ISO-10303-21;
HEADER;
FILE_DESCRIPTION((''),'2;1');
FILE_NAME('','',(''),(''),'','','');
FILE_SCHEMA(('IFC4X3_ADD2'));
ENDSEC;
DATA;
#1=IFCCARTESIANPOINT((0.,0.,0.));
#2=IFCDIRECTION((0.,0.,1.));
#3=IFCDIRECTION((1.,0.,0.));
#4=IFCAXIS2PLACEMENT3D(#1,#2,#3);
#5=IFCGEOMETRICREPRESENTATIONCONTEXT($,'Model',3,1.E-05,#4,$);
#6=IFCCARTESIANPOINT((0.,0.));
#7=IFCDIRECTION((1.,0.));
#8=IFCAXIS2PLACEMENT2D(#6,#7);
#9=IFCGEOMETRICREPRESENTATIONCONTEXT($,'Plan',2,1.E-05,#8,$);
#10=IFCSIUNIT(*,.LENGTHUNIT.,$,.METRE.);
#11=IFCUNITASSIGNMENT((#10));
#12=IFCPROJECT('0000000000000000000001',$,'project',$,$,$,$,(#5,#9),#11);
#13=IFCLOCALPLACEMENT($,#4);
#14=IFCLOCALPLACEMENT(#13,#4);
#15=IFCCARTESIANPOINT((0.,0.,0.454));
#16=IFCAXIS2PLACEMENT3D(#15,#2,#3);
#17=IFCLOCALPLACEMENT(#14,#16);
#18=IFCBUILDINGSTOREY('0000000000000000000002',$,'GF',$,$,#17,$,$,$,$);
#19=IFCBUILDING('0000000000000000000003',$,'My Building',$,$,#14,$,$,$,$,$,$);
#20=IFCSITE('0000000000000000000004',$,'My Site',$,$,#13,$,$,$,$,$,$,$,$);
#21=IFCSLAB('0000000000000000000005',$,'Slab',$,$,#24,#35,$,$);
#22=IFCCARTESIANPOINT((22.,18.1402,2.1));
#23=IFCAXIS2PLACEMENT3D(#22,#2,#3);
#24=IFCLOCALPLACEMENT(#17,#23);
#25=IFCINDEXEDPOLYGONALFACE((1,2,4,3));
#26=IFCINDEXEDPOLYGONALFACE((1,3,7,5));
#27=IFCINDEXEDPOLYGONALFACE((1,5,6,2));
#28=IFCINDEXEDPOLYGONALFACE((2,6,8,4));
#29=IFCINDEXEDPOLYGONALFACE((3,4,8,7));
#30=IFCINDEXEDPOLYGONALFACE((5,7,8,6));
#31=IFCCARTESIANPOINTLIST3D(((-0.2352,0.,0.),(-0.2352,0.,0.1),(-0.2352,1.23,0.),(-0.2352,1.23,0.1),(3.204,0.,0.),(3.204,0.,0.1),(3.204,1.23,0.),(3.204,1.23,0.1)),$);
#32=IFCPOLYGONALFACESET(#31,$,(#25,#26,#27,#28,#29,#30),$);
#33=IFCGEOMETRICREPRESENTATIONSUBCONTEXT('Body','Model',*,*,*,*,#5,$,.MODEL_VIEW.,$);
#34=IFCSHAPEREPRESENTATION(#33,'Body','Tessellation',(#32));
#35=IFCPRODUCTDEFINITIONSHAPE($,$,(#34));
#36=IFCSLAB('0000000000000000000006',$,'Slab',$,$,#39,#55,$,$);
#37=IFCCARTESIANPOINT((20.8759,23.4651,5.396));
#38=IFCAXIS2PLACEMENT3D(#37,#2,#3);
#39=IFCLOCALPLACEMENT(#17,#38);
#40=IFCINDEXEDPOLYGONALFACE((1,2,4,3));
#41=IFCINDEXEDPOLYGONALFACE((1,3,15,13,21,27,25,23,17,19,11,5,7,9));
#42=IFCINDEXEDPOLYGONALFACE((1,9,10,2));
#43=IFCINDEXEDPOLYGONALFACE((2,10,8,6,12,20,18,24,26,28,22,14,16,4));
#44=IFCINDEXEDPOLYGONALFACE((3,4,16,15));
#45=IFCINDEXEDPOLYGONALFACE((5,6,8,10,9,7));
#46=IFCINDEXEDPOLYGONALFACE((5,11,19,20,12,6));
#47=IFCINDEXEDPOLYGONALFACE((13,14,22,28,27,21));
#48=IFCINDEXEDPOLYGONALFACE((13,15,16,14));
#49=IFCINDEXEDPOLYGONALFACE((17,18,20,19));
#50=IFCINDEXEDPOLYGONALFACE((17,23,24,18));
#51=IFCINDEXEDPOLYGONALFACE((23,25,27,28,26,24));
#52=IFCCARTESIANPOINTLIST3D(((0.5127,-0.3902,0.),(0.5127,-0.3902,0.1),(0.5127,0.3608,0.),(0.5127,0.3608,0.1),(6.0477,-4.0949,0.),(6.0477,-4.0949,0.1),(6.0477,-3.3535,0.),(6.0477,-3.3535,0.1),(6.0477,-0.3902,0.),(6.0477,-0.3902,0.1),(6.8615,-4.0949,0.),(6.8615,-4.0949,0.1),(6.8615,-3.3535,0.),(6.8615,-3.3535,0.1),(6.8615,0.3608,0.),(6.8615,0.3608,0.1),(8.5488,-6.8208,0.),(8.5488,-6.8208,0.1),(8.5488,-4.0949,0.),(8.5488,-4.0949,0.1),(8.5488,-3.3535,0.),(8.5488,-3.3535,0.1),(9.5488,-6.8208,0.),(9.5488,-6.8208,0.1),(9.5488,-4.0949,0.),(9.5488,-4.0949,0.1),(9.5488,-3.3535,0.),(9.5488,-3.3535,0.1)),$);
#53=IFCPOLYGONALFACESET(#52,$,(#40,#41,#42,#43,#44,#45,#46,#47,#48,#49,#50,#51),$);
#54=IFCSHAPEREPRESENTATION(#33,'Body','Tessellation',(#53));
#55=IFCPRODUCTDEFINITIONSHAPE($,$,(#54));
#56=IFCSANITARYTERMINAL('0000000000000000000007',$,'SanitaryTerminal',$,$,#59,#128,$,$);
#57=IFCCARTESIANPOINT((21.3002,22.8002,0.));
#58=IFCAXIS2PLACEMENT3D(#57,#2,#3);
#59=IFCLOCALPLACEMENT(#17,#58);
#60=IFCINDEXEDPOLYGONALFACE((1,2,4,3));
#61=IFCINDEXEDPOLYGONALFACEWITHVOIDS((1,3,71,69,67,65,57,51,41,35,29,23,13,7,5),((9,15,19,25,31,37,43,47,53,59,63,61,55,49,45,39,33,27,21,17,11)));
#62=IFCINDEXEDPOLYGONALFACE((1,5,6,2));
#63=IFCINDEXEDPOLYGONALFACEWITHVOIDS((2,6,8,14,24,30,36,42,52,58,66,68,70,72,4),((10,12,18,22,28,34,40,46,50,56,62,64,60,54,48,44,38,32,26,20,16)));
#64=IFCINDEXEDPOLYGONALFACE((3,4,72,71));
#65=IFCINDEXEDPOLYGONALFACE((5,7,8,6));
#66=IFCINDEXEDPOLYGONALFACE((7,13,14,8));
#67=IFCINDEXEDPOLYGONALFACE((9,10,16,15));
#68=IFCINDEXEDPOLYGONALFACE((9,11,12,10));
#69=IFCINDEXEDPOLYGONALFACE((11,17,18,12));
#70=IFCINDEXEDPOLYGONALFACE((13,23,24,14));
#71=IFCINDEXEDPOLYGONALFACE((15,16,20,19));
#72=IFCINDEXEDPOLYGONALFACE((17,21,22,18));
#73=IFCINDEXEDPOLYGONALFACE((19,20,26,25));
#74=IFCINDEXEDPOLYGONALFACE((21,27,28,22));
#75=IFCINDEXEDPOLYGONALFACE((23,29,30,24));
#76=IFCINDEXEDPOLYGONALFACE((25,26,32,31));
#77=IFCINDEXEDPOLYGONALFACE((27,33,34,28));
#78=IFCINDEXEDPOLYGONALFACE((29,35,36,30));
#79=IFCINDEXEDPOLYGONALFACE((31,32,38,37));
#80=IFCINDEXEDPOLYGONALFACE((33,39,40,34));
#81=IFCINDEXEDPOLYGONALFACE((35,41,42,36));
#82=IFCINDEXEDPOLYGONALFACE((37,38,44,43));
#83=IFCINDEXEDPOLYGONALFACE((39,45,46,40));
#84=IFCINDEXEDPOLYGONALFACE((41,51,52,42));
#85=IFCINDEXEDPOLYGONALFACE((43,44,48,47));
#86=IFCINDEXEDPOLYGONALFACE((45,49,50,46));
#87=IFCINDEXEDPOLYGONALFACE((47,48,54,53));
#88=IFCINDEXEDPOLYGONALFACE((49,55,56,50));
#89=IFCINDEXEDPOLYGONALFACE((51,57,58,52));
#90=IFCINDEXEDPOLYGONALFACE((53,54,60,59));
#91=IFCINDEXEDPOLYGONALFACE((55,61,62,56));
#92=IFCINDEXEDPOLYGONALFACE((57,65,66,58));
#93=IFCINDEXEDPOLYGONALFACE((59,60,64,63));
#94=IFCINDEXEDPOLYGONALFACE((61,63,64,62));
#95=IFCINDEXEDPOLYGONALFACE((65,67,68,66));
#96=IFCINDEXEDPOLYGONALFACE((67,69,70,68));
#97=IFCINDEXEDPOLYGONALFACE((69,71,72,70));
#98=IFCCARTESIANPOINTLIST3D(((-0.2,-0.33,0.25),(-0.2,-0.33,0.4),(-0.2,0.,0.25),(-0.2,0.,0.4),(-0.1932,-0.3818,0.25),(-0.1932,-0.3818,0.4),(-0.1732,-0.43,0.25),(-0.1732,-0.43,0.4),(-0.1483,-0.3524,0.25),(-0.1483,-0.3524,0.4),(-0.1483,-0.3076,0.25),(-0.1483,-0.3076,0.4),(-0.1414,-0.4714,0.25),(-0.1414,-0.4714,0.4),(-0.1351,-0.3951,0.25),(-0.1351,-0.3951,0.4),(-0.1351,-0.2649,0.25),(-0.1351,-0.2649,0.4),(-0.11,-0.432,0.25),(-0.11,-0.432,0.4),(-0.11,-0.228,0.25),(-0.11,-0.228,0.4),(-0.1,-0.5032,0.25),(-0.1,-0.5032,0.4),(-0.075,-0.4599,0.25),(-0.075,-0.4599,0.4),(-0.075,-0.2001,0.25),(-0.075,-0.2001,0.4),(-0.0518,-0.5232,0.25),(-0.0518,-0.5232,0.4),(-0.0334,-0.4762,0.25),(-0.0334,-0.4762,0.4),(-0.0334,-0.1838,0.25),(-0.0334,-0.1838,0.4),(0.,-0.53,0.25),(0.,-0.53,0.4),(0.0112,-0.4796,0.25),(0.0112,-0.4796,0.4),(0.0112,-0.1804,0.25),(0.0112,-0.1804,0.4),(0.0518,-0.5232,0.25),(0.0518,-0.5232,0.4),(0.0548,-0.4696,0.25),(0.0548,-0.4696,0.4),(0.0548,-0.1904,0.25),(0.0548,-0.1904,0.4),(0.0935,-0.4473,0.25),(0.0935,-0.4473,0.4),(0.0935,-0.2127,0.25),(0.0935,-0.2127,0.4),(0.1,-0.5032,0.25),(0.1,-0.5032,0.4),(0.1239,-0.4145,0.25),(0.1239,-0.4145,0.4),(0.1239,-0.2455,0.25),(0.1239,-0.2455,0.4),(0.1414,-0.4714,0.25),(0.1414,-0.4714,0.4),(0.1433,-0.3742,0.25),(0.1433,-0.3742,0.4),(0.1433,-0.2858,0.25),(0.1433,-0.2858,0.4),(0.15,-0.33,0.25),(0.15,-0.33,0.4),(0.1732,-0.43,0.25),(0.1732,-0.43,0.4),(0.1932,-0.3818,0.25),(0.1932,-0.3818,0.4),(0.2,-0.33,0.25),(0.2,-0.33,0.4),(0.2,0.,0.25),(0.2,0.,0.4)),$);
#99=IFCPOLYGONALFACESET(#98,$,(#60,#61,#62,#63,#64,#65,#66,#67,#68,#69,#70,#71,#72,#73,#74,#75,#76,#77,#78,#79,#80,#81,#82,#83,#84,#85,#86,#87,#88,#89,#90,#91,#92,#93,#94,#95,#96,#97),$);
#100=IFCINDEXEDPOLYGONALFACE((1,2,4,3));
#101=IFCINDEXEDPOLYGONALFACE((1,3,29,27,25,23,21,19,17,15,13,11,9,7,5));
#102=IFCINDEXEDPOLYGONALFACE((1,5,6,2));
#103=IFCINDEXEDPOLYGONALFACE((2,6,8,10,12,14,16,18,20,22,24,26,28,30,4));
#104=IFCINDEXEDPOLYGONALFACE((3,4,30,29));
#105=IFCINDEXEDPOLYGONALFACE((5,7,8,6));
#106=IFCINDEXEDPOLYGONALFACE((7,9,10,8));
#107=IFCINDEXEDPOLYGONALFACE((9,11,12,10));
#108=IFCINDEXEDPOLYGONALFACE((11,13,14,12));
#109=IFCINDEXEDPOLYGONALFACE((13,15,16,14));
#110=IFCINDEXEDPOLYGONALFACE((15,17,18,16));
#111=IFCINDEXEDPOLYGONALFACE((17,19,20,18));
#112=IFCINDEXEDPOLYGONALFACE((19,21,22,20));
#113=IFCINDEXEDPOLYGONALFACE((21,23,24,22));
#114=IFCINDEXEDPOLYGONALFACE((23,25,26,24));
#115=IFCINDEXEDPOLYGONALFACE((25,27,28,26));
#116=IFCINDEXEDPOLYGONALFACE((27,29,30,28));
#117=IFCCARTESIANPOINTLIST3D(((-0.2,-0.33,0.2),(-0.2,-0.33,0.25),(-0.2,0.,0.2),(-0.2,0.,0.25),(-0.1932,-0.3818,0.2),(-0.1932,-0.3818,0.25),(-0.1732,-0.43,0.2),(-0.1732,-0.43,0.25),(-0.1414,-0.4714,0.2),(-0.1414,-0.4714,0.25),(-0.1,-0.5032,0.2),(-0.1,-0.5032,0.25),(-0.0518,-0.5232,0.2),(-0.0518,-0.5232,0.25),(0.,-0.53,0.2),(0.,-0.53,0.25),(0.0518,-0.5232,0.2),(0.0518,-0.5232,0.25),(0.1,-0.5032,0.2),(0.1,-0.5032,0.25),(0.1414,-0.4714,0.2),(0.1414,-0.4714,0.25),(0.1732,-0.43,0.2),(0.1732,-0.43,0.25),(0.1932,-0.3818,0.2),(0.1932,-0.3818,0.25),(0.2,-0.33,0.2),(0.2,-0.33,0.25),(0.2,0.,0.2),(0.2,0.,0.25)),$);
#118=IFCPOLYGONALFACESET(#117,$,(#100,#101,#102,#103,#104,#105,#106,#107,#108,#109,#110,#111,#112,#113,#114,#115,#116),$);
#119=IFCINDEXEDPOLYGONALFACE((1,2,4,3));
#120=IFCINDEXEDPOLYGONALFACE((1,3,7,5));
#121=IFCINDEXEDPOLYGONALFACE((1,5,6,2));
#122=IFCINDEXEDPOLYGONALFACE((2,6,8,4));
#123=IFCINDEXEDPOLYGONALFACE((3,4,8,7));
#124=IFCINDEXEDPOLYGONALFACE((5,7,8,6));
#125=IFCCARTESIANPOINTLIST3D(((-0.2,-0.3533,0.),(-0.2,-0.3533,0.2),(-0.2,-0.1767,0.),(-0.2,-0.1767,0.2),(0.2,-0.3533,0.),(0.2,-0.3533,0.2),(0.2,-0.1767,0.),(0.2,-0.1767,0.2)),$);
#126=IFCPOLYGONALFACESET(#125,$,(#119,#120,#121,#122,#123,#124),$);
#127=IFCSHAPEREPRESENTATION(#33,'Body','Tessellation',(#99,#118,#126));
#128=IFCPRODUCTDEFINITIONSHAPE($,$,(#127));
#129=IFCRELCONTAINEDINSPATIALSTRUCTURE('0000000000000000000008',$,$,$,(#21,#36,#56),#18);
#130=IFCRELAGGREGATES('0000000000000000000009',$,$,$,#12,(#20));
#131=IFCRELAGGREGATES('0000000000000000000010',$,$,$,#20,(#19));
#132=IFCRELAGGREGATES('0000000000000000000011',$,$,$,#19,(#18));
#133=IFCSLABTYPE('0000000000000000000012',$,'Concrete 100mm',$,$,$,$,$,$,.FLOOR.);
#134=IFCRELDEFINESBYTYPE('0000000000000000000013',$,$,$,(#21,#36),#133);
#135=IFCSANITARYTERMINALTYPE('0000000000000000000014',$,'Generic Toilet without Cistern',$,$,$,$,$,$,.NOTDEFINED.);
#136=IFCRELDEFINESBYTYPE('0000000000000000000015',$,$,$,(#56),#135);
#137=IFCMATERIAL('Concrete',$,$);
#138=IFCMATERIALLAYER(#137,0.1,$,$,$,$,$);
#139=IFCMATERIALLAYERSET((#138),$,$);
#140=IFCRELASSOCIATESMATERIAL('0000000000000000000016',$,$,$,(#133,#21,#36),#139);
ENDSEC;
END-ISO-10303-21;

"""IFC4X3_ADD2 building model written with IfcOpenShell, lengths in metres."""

from ifc_helpers import new_model, entity, si_unit, frame, frame_2d, origin_with_axes, origin_2d_with_axis, place, context, subcontext, project, spatial, line, arc, indexed_curve, circle_curve, outline, extrude, shape, source, transform, mapped, material, layer, layer_set, layer_usage, type_object, type_shapes, element, save


model = new_model("IFC4X3_ADD2")

# Units and contexts
model_context = context("Model", 3, precision=1e-05, world=origin_with_axes())
plan_context = context("Plan", 2, precision=1e-05, world=origin_2d_with_axis())
body_context_1 = subcontext(model_context, "Body", "Model", "MODEL_VIEW")
body_context_2 = subcontext(plan_context, "Body", "Plan", "PLAN_VIEW")
ifc_project = project(units=[si_unit("LENGTHUNIT", "METRE")], contexts=[model_context, plan_context])

# Site, building, storey
site_placement = place(None, origin_with_axes())
site = spatial("IfcSite", under=ifc_project, at=site_placement, Name="My Site")
building_placement = place(site_placement, origin_with_axes())
building = spatial("IfcBuilding", under=site, at=building_placement, Name="My Building")
storey_placement = place(building_placement, frame((0.0, 0.0, 0.454), z_axis=(0.0, 0.0, 1.0), x_axis=(1.0, 0.0, 0.0)))
storey = spatial("IfcBuildingStorey", under=building, at=storey_placement, Name="GF")

# Slabs
ifc_material_1 = material(Name="Concrete")
ifc_layer_1 = layer(ifc_material_1, 0.1)
ifc_layer_set_1 = layer_set([ifc_layer_1])
ifc_layer_usage_1 = layer_usage(ifc_layer_set_1, "AXIS3", "POSITIVE", 0.0)
slab_type = type_object("IfcSlabType", Name="Concrete 100mm", PredefinedType="FLOOR", material=ifc_layer_set_1)
slab_1_placement = place(storey_placement, frame((22.0, 18.1402, 2.1), z_axis=(0.0, 0.0, 1.0), x_axis=(1.0, 0.0, 0.0)))
element("IfcSlab", 1, at=slab_1_placement, inside=storey, type_object=slab_type, material=ifc_layer_usage_1, Name="Slab", context=body_context_1, shape_type="SweptSolid", body=[
    extrude(outline(indexed_curve([(3.204, 0.0), (-0.2352, 0.0), (-0.2352, 1.23), (3.204, 1.23)], segments=[line(3, 2), line(2, 1), line(1, 4), line(4, 3)], self_intersect=False)), None, (0.0, 0.0, 1.0), 0.1),
])
ifc_layer_usage_2 = layer_usage(ifc_layer_set_1, "AXIS3", "POSITIVE", 0.0)
slab_2_placement = place(storey_placement, frame((20.8759, 23.4651, 5.396), z_axis=(0.0, 0.0, 1.0), x_axis=(1.0, 0.0, 0.0)))
element("IfcSlab", 2, at=slab_2_placement, inside=storey, type_object=slab_type, material=ifc_layer_usage_2, Name="Slab", context=body_context_1, shape_type="SweptSolid", body=[
    extrude(outline(indexed_curve([(9.5488, -4.0949), (9.5488, -3.3535), (8.5488, -3.3535), (6.8615, -3.3535), (6.8615, 0.3608), (0.5127, 0.3608), (0.5127, -0.3902), (6.0477, -0.3902), (6.0477, -3.3535), (6.0477, -4.0949), (6.8615, -4.0949), (8.5488, -4.0949), (8.5488, -6.8208), (9.5488, -6.8208)], segments=[line(11, 12), line(12, 13), line(13, 14), line(14, 1), line(1, 2), line(2, 3), line(3, 4), line(4, 5), line(5, 6), line(6, 7), line(7, 8), line(8, 9), line(9, 10), line(10, 11)], self_intersect=False)), None, (0.0, 0.0, 1.0), 0.1),
])

# Sanitary terminal
sanitary_terminal_type_1 = type_object("IfcSanitaryTerminalType", Name="Generic Toilet without Cistern", PredefinedType="NOTDEFINED")
shared_shape_1 = source(origin_with_axes(), body_context_1, "Body", "SweptSolid", [
    extrude(outline(indexed_curve([(-0.2, 0.0), (0.2, 0.0), (0.2, -0.33), (0.1414, -0.4714), (0.0, -0.53), (-0.1414, -0.4714), (-0.2, -0.33)], segments=[line(1, 2), line(2, 3), arc(3, 4, 5), arc(5, 6, 7), line(7, 1)]), holes=[circle_curve(frame_2d((0.0, -0.33)), 0.15)]), frame((0.0, 0.0, 0.25), z_axis=(0.0, 0.0, 1.0), x_axis=(1.0, 0.0, 0.0)), (0.0, 0.0, 1.0), 0.15),
    extrude(outline(indexed_curve([(-0.2, 0.0), (0.2, 0.0), (0.2, -0.33), (0.1414, -0.4714), (0.0, -0.53), (-0.1414, -0.4714), (-0.2, -0.33)], segments=[line(1, 2), line(2, 3), arc(3, 4, 5), arc(5, 6, 7), line(7, 1)])), frame((0.0, 0.0, 0.2), z_axis=(0.0, 0.0, 1.0), x_axis=(1.0, 0.0, 0.0)), (0.0, 0.0, 1.0), 0.05),
    extrude(outline(indexed_curve([(-0.2, -0.1767), (0.2, -0.1767), (0.2, -0.3533), (-0.2, -0.3533)], segments=[line(1, 2, 3, 4, 1)])), origin_with_axes(), (0.0, 0.0, 1.0), 0.2),
])
shared_shape_2 = source(origin_with_axes(), body_context_2, "Body", "Annotation2D", [
    entity("IfcGeometricCurveSet", [entity("IfcIndexedPolyCurve", entity("IfcCartesianPointList2D", [[-0.1068, -0.124], [-0.0957, -0.1129], [-0.0804, -0.1088], [0.0804, -0.1088], [0.0957, -0.1129], [0.1068, -0.124], [0.1109, -0.1393], [0.1109, -0.3476], [0.1025, -0.3926], [0.0784, -0.4308], [0.0424, -0.4563], [0.0, -0.4652], [-0.0424, -0.4563], [-0.0784, -0.4308], [-0.1025, -0.3926], [-0.1109, -0.3476], [-0.1109, -0.1393]]), [entity("IfcLineIndex", [1, 2, 3, 4, 5, 6, 7, 8, 9, 10, 11, 12, 13, 14, 15, 16, 17, 1])]), entity("IfcIndexedPolyCurve", entity("IfcCartesianPointList2D", [[-0.1962, -0.2314], [-0.1848, -0.301], [-0.1764, -0.3339], [-0.1663, -0.3651], [-0.1546, -0.3944], [-0.1414, -0.4213], [-0.1269, -0.4458], [-0.1111, -0.4675], [-0.0943, -0.4862], [-0.0765, -0.5018], [-0.0581, -0.514], [-0.039, -0.5229], [-0.0196, -0.5282], [0.0, -0.53], [0.0196, -0.5282], [0.039, -0.5229], [0.0581, -0.514], [0.0765, -0.5018], [0.0943, -0.4862], [0.1111, -0.4675], [0.1269, -0.4458], [0.1414, -0.4213], [0.1546, -0.3944], [0.1663, -0.3651], [0.1764, -0.3339], [0.1848, -0.301], [0.1962, -0.2314], [0.2, -0.159], [0.1872, 0.0], [-0.1872, 0.0], [-0.2, -0.159]]), [entity("IfcLineIndex", [1, 2, 3, 4, 5, 6, 7, 8, 9, 10, 11, 12, 13, 14, 15, 16, 17, 18, 19, 20, 21, 22, 23, 24, 25, 26, 27, 28, 29, 30, 31, 1])])]),
])
type_shapes(sanitary_terminal_type_1, [shared_shape_1, shared_shape_2])
sanitary_terminal_1_placement = place(storey_placement, frame((21.3002, 22.8002, 0.0), z_axis=(0.0, 0.0, 1.0), x_axis=(1.0, 0.0, 0.0)))
element("IfcSanitaryTerminal", 3, at=sanitary_terminal_1_placement, inside=storey, type_object=sanitary_terminal_type_1, Name="SanitaryTerminal", shapes=[
    shape(body_context_1, "Body", "MappedRepresentation", [mapped(shared_shape_1, transform((0.0, 0.0, 0.0), x_axis=(1.0, 0.0, 0.0), y_axis=(0.0, 1.0, 0.0), z_axis=(0.0, 0.0, 1.0), scale=1.0))]),
    shape(body_context_2, "Body", "MappedRepresentation", [mapped(shared_shape_2, transform((0.0, 0.0, 0.0), x_axis=(1.0, 0.0, 0.0), y_axis=(0.0, 1.0, 0.0), z_axis=(0.0, 0.0, 1.0), scale=1.0))]),
])

save(model, "model.ifc")
